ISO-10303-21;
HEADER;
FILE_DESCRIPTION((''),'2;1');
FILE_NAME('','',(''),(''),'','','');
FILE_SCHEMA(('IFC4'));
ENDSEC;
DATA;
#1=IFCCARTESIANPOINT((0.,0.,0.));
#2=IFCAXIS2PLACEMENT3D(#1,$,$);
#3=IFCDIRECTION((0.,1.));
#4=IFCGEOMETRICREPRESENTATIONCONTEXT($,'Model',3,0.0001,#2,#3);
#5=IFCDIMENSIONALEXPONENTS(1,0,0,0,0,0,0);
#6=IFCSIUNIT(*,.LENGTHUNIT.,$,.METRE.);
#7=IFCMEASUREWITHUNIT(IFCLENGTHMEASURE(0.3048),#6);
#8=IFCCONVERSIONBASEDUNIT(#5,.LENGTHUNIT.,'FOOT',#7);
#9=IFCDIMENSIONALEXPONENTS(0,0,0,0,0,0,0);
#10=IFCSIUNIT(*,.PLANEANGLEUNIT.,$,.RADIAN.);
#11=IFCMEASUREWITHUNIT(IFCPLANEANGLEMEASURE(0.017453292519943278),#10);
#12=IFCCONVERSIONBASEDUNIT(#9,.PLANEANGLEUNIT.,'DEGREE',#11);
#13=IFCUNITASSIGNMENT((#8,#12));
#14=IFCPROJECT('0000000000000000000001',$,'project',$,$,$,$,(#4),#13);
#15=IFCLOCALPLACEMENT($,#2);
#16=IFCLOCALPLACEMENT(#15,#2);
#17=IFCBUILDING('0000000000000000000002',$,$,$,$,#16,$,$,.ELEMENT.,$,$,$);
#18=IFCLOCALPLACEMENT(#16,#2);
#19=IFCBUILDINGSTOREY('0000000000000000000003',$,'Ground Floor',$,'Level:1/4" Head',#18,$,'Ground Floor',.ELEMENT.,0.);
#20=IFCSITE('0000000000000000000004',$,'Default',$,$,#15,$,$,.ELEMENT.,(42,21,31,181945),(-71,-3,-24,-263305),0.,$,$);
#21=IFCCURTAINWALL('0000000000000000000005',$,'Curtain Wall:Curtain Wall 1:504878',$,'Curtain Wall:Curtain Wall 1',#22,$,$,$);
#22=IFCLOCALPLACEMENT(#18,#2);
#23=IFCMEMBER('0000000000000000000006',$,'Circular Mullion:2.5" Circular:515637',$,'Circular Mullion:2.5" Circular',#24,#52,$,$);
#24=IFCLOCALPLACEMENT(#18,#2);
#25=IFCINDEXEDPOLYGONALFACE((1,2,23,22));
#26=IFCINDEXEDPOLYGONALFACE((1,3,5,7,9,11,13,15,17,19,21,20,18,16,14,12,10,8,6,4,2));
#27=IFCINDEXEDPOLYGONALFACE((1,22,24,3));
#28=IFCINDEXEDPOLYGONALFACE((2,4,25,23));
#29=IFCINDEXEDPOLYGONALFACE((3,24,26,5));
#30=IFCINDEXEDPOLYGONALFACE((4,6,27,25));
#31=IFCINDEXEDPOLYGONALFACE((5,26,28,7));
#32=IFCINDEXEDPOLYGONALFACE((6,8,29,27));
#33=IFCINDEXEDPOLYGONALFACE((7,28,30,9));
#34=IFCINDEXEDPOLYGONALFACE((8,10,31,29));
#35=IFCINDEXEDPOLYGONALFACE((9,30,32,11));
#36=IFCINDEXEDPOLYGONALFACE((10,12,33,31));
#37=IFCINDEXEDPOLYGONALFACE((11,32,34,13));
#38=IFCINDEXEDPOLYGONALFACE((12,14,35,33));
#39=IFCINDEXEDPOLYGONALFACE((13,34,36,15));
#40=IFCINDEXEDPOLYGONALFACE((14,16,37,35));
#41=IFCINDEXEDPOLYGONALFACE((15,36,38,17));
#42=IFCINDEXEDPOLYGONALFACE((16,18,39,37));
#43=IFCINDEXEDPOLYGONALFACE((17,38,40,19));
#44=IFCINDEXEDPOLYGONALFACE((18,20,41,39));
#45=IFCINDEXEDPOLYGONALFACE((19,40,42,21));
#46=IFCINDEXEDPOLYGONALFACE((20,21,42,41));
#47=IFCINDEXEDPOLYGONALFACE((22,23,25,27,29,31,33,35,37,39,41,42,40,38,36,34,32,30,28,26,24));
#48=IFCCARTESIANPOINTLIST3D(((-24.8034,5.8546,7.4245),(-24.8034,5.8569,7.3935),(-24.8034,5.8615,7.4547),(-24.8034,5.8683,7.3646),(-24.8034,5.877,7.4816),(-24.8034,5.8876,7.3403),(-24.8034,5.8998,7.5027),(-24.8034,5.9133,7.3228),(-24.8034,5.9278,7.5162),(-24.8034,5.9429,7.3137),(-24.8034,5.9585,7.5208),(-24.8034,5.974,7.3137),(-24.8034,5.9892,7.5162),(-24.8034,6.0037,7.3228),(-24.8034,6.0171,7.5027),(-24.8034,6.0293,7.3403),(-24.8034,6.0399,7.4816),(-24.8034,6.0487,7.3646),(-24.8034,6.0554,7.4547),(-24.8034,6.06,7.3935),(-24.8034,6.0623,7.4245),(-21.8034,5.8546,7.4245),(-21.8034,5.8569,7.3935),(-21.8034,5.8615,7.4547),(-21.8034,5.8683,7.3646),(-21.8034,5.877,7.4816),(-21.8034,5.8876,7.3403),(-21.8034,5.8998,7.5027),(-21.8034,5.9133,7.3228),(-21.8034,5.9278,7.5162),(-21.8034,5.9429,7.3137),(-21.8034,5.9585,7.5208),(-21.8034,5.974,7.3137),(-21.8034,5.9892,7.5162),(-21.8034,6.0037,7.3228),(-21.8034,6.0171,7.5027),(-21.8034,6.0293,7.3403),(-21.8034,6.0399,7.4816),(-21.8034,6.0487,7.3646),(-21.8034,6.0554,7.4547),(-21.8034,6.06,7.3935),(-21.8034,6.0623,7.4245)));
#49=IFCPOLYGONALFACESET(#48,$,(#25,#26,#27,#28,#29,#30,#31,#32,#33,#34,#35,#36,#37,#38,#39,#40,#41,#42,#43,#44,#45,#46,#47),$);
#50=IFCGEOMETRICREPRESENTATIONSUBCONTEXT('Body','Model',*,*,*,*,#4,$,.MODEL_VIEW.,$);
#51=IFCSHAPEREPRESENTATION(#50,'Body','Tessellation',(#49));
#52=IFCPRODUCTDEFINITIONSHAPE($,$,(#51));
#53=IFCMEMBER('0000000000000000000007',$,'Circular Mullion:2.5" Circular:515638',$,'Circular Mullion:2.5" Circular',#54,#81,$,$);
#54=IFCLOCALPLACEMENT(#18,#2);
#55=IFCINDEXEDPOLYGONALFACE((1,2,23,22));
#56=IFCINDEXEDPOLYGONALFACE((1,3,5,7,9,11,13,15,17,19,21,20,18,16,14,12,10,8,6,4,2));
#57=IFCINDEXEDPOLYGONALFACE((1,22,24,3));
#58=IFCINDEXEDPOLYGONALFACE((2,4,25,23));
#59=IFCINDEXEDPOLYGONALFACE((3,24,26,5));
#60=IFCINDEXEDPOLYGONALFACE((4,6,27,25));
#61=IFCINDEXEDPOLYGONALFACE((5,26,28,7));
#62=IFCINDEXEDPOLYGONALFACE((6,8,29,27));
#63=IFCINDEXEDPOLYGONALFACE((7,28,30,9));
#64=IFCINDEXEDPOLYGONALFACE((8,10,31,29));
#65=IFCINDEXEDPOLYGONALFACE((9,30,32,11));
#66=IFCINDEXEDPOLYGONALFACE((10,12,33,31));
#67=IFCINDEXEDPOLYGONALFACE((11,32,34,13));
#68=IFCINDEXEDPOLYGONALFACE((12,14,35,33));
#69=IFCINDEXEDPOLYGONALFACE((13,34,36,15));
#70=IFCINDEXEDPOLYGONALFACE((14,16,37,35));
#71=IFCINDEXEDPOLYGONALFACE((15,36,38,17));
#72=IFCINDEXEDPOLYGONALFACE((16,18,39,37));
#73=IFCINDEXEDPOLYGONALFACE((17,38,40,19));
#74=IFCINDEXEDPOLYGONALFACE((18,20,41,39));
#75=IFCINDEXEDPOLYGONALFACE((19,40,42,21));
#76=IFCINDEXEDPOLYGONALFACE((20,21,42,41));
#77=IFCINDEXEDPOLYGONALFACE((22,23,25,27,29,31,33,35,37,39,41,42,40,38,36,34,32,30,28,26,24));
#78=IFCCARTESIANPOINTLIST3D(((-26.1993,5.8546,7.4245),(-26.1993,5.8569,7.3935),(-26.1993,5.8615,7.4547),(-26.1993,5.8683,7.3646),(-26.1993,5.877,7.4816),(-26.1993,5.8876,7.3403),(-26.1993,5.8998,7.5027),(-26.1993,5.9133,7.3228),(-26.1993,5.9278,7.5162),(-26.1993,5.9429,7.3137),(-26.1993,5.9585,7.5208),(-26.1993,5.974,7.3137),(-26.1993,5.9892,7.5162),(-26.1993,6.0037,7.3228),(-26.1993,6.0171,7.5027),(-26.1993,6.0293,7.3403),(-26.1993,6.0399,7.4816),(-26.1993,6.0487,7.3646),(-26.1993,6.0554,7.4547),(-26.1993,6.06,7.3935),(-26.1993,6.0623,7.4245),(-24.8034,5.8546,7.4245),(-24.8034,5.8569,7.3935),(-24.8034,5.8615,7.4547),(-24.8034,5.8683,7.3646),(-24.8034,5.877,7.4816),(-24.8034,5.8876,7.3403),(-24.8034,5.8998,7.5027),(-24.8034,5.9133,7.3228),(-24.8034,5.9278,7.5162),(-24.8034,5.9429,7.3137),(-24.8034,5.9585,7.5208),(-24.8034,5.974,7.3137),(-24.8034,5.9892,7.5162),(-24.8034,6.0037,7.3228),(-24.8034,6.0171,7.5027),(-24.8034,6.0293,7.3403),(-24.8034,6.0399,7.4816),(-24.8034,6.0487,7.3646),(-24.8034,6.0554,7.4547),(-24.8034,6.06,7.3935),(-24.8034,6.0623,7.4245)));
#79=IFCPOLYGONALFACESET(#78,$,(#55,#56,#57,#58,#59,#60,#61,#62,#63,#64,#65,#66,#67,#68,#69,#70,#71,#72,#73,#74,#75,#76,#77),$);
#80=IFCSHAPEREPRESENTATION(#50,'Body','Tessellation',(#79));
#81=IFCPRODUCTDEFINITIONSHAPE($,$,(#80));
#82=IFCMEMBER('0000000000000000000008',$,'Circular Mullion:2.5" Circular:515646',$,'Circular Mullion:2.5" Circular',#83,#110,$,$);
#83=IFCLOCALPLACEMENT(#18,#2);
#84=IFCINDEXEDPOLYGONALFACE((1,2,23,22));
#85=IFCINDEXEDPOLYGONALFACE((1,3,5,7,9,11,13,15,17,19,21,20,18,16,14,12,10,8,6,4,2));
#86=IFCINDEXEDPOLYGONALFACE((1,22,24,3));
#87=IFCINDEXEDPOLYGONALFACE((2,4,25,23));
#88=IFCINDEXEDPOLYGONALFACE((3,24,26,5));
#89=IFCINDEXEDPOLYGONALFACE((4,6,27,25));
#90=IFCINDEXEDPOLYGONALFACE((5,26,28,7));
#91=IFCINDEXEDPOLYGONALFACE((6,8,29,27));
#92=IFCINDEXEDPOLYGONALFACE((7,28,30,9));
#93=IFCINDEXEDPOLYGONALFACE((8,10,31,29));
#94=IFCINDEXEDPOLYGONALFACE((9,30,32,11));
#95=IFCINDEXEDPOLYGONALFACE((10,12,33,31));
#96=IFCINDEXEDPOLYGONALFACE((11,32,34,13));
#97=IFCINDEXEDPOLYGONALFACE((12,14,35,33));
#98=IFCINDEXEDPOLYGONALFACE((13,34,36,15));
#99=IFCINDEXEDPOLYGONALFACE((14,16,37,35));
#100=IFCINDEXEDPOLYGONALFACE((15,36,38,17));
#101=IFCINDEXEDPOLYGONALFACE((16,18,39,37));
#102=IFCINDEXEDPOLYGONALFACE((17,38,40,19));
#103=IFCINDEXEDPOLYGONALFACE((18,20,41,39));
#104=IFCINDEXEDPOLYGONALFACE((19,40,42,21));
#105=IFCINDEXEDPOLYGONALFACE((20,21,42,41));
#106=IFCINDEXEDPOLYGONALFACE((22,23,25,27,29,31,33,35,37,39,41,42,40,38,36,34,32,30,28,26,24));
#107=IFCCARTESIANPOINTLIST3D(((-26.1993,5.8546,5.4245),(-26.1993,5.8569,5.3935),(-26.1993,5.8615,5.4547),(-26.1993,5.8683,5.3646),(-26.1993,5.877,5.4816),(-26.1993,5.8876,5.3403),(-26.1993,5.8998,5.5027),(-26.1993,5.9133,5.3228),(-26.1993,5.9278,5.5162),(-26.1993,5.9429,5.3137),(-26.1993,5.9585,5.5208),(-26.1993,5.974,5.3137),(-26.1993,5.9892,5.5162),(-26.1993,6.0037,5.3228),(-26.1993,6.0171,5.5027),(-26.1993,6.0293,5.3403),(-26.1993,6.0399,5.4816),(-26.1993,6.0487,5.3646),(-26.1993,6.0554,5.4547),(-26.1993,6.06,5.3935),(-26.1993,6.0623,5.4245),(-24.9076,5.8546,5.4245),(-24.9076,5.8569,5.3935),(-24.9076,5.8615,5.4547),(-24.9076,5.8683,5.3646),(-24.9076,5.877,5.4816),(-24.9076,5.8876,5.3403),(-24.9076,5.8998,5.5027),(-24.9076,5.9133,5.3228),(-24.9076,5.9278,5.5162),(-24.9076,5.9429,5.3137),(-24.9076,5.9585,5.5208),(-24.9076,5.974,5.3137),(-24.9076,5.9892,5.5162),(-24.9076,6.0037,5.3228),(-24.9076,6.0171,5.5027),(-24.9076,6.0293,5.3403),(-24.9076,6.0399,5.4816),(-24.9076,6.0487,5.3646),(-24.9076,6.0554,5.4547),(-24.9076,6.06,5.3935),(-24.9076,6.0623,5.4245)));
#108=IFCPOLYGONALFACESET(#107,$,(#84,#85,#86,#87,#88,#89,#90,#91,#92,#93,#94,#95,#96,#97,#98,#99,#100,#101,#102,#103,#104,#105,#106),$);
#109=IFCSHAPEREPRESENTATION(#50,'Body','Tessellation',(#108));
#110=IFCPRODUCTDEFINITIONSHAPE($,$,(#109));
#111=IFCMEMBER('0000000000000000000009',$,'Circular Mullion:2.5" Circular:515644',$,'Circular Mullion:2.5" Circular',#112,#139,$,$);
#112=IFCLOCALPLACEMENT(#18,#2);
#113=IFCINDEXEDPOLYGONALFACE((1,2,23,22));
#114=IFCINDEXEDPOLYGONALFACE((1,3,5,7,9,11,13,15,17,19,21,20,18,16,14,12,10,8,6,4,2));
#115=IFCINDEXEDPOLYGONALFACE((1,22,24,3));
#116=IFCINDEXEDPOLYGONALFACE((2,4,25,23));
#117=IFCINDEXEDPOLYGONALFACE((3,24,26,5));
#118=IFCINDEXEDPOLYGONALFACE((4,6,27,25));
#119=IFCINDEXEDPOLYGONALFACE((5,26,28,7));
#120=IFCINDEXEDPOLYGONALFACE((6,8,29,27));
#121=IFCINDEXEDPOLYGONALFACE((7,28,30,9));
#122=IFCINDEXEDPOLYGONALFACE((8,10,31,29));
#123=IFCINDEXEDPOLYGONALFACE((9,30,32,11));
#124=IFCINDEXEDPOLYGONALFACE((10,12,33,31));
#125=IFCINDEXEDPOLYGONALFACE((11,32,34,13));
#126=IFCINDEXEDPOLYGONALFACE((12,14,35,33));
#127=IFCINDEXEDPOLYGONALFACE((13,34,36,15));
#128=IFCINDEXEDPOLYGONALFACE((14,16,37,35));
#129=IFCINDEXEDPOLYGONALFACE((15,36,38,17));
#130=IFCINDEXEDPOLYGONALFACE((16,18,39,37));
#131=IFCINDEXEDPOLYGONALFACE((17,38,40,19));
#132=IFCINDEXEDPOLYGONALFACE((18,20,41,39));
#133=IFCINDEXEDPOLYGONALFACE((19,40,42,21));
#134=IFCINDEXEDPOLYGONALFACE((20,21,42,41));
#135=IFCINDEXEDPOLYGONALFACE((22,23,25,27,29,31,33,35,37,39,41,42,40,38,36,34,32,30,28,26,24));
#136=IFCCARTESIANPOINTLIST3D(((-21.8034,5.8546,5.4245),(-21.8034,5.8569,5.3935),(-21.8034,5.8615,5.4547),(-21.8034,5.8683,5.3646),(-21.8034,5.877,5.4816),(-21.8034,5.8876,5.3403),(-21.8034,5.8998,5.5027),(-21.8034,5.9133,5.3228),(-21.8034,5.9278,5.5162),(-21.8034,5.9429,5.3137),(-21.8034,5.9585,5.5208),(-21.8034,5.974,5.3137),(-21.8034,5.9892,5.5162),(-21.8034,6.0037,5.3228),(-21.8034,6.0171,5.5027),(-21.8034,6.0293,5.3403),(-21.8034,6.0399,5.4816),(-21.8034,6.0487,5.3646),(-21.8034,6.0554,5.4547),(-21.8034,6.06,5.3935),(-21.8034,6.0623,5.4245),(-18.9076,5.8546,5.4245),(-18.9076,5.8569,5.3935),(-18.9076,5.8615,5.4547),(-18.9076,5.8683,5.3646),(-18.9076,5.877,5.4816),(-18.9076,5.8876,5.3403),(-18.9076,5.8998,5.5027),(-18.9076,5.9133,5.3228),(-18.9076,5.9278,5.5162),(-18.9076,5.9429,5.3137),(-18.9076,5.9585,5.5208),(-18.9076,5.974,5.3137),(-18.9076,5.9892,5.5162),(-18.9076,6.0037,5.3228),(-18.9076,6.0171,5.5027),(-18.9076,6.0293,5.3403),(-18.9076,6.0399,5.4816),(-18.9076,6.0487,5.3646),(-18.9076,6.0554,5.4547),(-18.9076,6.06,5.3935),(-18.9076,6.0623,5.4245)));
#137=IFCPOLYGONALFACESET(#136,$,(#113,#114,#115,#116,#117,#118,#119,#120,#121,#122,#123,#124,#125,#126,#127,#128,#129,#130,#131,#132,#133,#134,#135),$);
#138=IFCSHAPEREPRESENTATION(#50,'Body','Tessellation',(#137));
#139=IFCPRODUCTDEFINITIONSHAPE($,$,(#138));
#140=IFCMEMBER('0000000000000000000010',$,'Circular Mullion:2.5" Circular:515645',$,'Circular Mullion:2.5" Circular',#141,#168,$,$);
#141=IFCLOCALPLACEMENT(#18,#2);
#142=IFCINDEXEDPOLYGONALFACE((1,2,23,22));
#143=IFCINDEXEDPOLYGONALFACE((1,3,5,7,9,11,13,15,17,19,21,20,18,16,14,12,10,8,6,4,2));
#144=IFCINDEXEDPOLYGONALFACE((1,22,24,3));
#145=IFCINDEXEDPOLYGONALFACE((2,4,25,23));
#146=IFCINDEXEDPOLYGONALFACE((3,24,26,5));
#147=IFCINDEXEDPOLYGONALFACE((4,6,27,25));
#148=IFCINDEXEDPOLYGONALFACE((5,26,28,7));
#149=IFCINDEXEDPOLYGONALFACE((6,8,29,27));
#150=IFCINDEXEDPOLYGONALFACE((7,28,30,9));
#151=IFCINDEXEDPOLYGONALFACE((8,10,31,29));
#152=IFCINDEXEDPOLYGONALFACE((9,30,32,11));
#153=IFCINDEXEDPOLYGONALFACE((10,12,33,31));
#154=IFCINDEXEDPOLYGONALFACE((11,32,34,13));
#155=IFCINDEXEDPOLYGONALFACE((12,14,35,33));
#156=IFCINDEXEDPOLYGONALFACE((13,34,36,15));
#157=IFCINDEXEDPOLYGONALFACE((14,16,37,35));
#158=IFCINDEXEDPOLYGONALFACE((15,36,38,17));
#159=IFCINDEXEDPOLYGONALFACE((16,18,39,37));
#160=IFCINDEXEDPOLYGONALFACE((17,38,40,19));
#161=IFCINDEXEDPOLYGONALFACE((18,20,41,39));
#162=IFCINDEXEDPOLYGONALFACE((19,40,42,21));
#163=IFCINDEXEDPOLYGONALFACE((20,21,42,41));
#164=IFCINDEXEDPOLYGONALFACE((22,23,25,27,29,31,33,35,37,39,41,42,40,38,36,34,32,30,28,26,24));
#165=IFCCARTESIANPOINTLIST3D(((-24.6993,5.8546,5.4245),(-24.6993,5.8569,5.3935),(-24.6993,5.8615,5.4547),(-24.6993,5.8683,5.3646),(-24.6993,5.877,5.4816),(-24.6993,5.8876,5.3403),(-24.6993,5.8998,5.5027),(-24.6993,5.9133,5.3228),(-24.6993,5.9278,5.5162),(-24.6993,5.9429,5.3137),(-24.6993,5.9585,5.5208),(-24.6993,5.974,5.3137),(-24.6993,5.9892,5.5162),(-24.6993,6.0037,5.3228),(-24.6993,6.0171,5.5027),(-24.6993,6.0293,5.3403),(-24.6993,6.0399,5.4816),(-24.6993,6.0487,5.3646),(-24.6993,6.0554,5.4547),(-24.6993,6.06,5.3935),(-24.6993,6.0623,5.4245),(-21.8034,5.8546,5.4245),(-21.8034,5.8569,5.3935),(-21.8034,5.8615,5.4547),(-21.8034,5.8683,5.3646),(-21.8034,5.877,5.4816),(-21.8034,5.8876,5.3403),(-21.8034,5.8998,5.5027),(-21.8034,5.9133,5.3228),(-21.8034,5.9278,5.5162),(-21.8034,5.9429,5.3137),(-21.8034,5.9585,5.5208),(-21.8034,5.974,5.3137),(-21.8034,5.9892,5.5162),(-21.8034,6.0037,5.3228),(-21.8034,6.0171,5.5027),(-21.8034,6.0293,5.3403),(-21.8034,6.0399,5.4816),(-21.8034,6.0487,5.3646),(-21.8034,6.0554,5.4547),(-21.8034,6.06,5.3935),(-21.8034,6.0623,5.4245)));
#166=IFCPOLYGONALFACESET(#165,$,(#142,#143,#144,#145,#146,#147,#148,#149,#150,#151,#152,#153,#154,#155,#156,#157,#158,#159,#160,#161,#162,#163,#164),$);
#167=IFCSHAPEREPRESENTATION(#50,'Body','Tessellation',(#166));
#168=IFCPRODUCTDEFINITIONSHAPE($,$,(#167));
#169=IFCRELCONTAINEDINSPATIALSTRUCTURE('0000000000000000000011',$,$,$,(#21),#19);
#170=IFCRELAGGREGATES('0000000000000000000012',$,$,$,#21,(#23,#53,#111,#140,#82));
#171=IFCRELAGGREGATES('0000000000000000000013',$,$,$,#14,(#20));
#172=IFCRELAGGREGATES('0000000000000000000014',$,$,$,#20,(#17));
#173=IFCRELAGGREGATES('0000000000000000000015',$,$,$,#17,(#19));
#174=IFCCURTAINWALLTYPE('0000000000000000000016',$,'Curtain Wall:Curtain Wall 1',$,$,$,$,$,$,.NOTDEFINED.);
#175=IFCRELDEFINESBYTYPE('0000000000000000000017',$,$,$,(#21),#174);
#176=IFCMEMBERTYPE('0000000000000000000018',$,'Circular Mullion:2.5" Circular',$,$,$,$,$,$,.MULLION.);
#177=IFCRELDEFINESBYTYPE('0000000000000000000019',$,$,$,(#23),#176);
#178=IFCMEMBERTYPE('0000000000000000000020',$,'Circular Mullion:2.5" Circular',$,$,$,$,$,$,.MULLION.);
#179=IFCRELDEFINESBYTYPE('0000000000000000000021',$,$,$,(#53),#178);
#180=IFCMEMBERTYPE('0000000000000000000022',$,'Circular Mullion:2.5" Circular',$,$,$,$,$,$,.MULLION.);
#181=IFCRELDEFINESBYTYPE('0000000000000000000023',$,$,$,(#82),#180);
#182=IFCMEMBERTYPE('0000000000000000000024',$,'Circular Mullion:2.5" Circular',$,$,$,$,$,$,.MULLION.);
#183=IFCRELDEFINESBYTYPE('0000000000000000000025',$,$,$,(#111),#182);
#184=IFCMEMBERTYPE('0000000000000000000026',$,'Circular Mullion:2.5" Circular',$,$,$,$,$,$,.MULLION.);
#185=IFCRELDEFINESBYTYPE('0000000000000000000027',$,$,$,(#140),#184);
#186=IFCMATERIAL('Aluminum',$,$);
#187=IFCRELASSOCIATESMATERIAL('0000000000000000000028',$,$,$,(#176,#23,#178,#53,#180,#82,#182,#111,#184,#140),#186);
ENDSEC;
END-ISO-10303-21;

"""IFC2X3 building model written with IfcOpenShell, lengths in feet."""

from ifc_helpers import new_model, entity, si_unit, converted_unit, direction, frame, frame_2d, origin, place, context, subcontext, project, spatial, circle, extrude, source, transform, mapped, material, type_object, type_shapes, element, aggregate, save


model = new_model("IFC2X3")

# Units and contexts
model_context = context("Model", 3, precision=0.0001, world=origin(), true_north=direction((0.0, 1.0)))
body_context = subcontext(model_context, "Body", "Model", "MODEL_VIEW")
ifc_project = project(units=[converted_unit("LENGTHUNIT", "FOOT", entity("IfcLengthMeasure", 0.3048), si_unit("LENGTHUNIT", "METRE"), dimensions=[1, 0, 0, 0, 0, 0, 0]), converted_unit("PLANEANGLEUNIT", "DEGREE", entity("IfcPlaneAngleMeasure", 0.017453292519943278), si_unit("PLANEANGLEUNIT", "RADIAN"), dimensions=[0, 0, 0, 0, 0, 0, 0])], contexts=[model_context])

# Site, building, storey
site_placement = place(None, origin())
site = spatial("IfcSite", under=ifc_project, at=site_placement, Name="Default", CompositionType="ELEMENT", RefLatitude=(42, 21, 31, 181945), RefLongitude=(-71, -3, -24, -263305), RefElevation=0.0)
building_placement = place(site_placement, origin())
building = spatial("IfcBuilding", under=site, at=building_placement, CompositionType="ELEMENT")
storey_placement = place(building_placement, origin())
storey = spatial("IfcBuildingStorey", under=building, at=storey_placement, Name="Ground Floor", ObjectType="Level:1/4\" Head", LongName="Ground Floor", CompositionType="ELEMENT", Elevation=0.0)

# Curtain wall, members
curtain_wall_type = type_object("IfcCurtainWallType", Name="Curtain Wall:Curtain Wall 1", PredefinedType="NOTDEFINED")
curtain_wall_placement = place(storey_placement, origin())
curtain_wall = element("IfcCurtainWall", 1, at=curtain_wall_placement, inside=storey, type_object=curtain_wall_type, Name="Curtain Wall:Curtain Wall 1:504878", ObjectType="Curtain Wall:Curtain Wall 1")
ifc_material_1 = material(Name="Aluminum")
member_type_1 = type_object("IfcMemberType", Name="Circular Mullion:2.5\" Circular", PredefinedType="MULLION", material=ifc_material_1)
shared_shape_1 = source(origin(), body_context, "Body", "SweptSolid", [
    extrude(circle(Radius=0.1042, at=frame_2d((0.0, 0.0), x_axis=(1.0, 0.0))), frame((0.0, 0.0, -3.0)), (0.0, 0.0, 1.0), 3.0),
])
type_shapes(member_type_1, [shared_shape_1])
member_1_placement = place(curtain_wall_placement, frame((-24.8034, 5.9585, 7.4167), z_axis=(-1.0, 0.0, 0.0), x_axis=(0.0, 0.0, 1.0)))
member_1 = element("IfcMember", 2, at=member_1_placement, type_object=member_type_1, material=ifc_material_1, Name="Circular Mullion:2.5\" Circular:515637", ObjectType="Circular Mullion:2.5\" Circular", context=body_context, shape_type="MappedRepresentation", body=[
    mapped(shared_shape_1, transform((0.0, 0.0, 0.0), scale=1.0)),
])
member_type_2 = type_object("IfcMemberType", Name="Circular Mullion:2.5\" Circular", PredefinedType="MULLION", material=ifc_material_1)
shared_shape_2 = source(origin(), body_context, "Body", "SweptSolid", [
    extrude(circle(Radius=0.1042, at=frame_2d((0.0, 0.0), x_axis=(1.0, 0.0))), frame((0.0, 0.0, -1.3958)), (0.0, 0.0, 1.0), 1.3958),
])
type_shapes(member_type_2, [shared_shape_2])
member_2_placement = place(curtain_wall_placement, frame((-26.1993, 5.9585, 7.4167), z_axis=(-1.0, 0.0, 0.0), x_axis=(0.0, 0.0, 1.0)))
member_2 = element("IfcMember", 3, at=member_2_placement, type_object=member_type_2, material=ifc_material_1, Name="Circular Mullion:2.5\" Circular:515638", ObjectType="Circular Mullion:2.5\" Circular", context=body_context, shape_type="MappedRepresentation", body=[
    mapped(shared_shape_2, transform((0.0, 0.0, 0.0), scale=1.0)),
])
member_type_3 = type_object("IfcMemberType", Name="Circular Mullion:2.5\" Circular", PredefinedType="MULLION", material=ifc_material_1)
shared_shape_3 = source(origin(), body_context, "Body", "SweptSolid", [
    extrude(circle(Radius=0.1042, at=frame_2d((0.0, 0.0), x_axis=(1.0, 0.0))), frame((0.0, 0.0, -1.2917)), (0.0, 0.0, 1.0), 1.2917),
])
type_shapes(member_type_3, [shared_shape_3])
member_3_placement = place(curtain_wall_placement, frame((-26.1993, 5.9585, 5.4167), z_axis=(-1.0, 0.0, 0.0), x_axis=(0.0, 0.0, 1.0)))
member_3 = element("IfcMember", 4, at=member_3_placement, type_object=member_type_3, material=ifc_material_1, Name="Circular Mullion:2.5\" Circular:515646", ObjectType="Circular Mullion:2.5\" Circular", context=body_context, shape_type="MappedRepresentation", body=[
    mapped(shared_shape_3, transform((0.0, 0.0, 0.0), scale=1.0)),
])
member_type_4 = type_object("IfcMemberType", Name="Circular Mullion:2.5\" Circular", PredefinedType="MULLION", material=ifc_material_1)
shared_shape_4 = source(origin(), body_context, "Body", "SweptSolid", [
    extrude(circle(Radius=0.1042, at=frame_2d((0.0, 0.0), x_axis=(1.0, 0.0))), frame((0.0, 0.0, -2.8958)), (0.0, 0.0, 1.0), 2.8958),
])
type_shapes(member_type_4, [shared_shape_4])
member_4_placement = place(curtain_wall_placement, frame((-21.8034, 5.9585, 5.4167), z_axis=(-1.0, 0.0, 0.0), x_axis=(0.0, 0.0, 1.0)))
member_4 = element("IfcMember", 5, at=member_4_placement, type_object=member_type_4, material=ifc_material_1, Name="Circular Mullion:2.5\" Circular:515644", ObjectType="Circular Mullion:2.5\" Circular", context=body_context, shape_type="MappedRepresentation", body=[
    mapped(shared_shape_4, transform((0.0, 0.0, 0.0), scale=1.0)),
])
member_type_5 = type_object("IfcMemberType", Name="Circular Mullion:2.5\" Circular", PredefinedType="MULLION", material=ifc_material_1)
shared_shape_5 = source(origin(), body_context, "Body", "SweptSolid", [
    extrude(circle(Radius=0.1042, at=frame_2d((0.0, 0.0), x_axis=(1.0, 0.0))), frame((0.0, 0.0, -2.8958)), (0.0, 0.0, 1.0), 2.8958),
])
type_shapes(member_type_5, [shared_shape_5])
member_5_placement = place(curtain_wall_placement, frame((-24.6993, 5.9585, 5.4167), z_axis=(-1.0, 0.0, 0.0), x_axis=(0.0, 0.0, 1.0)))
member_5 = element("IfcMember", 6, at=member_5_placement, type_object=member_type_5, material=ifc_material_1, Name="Circular Mullion:2.5\" Circular:515645", ObjectType="Circular Mullion:2.5\" Circular", context=body_context, shape_type="MappedRepresentation", body=[
    mapped(shared_shape_5, transform((0.0, 0.0, 0.0), scale=1.0)),
])
aggregate(curtain_wall, [member_1, member_2, member_4, member_5, member_3])

save(model, "model.ifc")
